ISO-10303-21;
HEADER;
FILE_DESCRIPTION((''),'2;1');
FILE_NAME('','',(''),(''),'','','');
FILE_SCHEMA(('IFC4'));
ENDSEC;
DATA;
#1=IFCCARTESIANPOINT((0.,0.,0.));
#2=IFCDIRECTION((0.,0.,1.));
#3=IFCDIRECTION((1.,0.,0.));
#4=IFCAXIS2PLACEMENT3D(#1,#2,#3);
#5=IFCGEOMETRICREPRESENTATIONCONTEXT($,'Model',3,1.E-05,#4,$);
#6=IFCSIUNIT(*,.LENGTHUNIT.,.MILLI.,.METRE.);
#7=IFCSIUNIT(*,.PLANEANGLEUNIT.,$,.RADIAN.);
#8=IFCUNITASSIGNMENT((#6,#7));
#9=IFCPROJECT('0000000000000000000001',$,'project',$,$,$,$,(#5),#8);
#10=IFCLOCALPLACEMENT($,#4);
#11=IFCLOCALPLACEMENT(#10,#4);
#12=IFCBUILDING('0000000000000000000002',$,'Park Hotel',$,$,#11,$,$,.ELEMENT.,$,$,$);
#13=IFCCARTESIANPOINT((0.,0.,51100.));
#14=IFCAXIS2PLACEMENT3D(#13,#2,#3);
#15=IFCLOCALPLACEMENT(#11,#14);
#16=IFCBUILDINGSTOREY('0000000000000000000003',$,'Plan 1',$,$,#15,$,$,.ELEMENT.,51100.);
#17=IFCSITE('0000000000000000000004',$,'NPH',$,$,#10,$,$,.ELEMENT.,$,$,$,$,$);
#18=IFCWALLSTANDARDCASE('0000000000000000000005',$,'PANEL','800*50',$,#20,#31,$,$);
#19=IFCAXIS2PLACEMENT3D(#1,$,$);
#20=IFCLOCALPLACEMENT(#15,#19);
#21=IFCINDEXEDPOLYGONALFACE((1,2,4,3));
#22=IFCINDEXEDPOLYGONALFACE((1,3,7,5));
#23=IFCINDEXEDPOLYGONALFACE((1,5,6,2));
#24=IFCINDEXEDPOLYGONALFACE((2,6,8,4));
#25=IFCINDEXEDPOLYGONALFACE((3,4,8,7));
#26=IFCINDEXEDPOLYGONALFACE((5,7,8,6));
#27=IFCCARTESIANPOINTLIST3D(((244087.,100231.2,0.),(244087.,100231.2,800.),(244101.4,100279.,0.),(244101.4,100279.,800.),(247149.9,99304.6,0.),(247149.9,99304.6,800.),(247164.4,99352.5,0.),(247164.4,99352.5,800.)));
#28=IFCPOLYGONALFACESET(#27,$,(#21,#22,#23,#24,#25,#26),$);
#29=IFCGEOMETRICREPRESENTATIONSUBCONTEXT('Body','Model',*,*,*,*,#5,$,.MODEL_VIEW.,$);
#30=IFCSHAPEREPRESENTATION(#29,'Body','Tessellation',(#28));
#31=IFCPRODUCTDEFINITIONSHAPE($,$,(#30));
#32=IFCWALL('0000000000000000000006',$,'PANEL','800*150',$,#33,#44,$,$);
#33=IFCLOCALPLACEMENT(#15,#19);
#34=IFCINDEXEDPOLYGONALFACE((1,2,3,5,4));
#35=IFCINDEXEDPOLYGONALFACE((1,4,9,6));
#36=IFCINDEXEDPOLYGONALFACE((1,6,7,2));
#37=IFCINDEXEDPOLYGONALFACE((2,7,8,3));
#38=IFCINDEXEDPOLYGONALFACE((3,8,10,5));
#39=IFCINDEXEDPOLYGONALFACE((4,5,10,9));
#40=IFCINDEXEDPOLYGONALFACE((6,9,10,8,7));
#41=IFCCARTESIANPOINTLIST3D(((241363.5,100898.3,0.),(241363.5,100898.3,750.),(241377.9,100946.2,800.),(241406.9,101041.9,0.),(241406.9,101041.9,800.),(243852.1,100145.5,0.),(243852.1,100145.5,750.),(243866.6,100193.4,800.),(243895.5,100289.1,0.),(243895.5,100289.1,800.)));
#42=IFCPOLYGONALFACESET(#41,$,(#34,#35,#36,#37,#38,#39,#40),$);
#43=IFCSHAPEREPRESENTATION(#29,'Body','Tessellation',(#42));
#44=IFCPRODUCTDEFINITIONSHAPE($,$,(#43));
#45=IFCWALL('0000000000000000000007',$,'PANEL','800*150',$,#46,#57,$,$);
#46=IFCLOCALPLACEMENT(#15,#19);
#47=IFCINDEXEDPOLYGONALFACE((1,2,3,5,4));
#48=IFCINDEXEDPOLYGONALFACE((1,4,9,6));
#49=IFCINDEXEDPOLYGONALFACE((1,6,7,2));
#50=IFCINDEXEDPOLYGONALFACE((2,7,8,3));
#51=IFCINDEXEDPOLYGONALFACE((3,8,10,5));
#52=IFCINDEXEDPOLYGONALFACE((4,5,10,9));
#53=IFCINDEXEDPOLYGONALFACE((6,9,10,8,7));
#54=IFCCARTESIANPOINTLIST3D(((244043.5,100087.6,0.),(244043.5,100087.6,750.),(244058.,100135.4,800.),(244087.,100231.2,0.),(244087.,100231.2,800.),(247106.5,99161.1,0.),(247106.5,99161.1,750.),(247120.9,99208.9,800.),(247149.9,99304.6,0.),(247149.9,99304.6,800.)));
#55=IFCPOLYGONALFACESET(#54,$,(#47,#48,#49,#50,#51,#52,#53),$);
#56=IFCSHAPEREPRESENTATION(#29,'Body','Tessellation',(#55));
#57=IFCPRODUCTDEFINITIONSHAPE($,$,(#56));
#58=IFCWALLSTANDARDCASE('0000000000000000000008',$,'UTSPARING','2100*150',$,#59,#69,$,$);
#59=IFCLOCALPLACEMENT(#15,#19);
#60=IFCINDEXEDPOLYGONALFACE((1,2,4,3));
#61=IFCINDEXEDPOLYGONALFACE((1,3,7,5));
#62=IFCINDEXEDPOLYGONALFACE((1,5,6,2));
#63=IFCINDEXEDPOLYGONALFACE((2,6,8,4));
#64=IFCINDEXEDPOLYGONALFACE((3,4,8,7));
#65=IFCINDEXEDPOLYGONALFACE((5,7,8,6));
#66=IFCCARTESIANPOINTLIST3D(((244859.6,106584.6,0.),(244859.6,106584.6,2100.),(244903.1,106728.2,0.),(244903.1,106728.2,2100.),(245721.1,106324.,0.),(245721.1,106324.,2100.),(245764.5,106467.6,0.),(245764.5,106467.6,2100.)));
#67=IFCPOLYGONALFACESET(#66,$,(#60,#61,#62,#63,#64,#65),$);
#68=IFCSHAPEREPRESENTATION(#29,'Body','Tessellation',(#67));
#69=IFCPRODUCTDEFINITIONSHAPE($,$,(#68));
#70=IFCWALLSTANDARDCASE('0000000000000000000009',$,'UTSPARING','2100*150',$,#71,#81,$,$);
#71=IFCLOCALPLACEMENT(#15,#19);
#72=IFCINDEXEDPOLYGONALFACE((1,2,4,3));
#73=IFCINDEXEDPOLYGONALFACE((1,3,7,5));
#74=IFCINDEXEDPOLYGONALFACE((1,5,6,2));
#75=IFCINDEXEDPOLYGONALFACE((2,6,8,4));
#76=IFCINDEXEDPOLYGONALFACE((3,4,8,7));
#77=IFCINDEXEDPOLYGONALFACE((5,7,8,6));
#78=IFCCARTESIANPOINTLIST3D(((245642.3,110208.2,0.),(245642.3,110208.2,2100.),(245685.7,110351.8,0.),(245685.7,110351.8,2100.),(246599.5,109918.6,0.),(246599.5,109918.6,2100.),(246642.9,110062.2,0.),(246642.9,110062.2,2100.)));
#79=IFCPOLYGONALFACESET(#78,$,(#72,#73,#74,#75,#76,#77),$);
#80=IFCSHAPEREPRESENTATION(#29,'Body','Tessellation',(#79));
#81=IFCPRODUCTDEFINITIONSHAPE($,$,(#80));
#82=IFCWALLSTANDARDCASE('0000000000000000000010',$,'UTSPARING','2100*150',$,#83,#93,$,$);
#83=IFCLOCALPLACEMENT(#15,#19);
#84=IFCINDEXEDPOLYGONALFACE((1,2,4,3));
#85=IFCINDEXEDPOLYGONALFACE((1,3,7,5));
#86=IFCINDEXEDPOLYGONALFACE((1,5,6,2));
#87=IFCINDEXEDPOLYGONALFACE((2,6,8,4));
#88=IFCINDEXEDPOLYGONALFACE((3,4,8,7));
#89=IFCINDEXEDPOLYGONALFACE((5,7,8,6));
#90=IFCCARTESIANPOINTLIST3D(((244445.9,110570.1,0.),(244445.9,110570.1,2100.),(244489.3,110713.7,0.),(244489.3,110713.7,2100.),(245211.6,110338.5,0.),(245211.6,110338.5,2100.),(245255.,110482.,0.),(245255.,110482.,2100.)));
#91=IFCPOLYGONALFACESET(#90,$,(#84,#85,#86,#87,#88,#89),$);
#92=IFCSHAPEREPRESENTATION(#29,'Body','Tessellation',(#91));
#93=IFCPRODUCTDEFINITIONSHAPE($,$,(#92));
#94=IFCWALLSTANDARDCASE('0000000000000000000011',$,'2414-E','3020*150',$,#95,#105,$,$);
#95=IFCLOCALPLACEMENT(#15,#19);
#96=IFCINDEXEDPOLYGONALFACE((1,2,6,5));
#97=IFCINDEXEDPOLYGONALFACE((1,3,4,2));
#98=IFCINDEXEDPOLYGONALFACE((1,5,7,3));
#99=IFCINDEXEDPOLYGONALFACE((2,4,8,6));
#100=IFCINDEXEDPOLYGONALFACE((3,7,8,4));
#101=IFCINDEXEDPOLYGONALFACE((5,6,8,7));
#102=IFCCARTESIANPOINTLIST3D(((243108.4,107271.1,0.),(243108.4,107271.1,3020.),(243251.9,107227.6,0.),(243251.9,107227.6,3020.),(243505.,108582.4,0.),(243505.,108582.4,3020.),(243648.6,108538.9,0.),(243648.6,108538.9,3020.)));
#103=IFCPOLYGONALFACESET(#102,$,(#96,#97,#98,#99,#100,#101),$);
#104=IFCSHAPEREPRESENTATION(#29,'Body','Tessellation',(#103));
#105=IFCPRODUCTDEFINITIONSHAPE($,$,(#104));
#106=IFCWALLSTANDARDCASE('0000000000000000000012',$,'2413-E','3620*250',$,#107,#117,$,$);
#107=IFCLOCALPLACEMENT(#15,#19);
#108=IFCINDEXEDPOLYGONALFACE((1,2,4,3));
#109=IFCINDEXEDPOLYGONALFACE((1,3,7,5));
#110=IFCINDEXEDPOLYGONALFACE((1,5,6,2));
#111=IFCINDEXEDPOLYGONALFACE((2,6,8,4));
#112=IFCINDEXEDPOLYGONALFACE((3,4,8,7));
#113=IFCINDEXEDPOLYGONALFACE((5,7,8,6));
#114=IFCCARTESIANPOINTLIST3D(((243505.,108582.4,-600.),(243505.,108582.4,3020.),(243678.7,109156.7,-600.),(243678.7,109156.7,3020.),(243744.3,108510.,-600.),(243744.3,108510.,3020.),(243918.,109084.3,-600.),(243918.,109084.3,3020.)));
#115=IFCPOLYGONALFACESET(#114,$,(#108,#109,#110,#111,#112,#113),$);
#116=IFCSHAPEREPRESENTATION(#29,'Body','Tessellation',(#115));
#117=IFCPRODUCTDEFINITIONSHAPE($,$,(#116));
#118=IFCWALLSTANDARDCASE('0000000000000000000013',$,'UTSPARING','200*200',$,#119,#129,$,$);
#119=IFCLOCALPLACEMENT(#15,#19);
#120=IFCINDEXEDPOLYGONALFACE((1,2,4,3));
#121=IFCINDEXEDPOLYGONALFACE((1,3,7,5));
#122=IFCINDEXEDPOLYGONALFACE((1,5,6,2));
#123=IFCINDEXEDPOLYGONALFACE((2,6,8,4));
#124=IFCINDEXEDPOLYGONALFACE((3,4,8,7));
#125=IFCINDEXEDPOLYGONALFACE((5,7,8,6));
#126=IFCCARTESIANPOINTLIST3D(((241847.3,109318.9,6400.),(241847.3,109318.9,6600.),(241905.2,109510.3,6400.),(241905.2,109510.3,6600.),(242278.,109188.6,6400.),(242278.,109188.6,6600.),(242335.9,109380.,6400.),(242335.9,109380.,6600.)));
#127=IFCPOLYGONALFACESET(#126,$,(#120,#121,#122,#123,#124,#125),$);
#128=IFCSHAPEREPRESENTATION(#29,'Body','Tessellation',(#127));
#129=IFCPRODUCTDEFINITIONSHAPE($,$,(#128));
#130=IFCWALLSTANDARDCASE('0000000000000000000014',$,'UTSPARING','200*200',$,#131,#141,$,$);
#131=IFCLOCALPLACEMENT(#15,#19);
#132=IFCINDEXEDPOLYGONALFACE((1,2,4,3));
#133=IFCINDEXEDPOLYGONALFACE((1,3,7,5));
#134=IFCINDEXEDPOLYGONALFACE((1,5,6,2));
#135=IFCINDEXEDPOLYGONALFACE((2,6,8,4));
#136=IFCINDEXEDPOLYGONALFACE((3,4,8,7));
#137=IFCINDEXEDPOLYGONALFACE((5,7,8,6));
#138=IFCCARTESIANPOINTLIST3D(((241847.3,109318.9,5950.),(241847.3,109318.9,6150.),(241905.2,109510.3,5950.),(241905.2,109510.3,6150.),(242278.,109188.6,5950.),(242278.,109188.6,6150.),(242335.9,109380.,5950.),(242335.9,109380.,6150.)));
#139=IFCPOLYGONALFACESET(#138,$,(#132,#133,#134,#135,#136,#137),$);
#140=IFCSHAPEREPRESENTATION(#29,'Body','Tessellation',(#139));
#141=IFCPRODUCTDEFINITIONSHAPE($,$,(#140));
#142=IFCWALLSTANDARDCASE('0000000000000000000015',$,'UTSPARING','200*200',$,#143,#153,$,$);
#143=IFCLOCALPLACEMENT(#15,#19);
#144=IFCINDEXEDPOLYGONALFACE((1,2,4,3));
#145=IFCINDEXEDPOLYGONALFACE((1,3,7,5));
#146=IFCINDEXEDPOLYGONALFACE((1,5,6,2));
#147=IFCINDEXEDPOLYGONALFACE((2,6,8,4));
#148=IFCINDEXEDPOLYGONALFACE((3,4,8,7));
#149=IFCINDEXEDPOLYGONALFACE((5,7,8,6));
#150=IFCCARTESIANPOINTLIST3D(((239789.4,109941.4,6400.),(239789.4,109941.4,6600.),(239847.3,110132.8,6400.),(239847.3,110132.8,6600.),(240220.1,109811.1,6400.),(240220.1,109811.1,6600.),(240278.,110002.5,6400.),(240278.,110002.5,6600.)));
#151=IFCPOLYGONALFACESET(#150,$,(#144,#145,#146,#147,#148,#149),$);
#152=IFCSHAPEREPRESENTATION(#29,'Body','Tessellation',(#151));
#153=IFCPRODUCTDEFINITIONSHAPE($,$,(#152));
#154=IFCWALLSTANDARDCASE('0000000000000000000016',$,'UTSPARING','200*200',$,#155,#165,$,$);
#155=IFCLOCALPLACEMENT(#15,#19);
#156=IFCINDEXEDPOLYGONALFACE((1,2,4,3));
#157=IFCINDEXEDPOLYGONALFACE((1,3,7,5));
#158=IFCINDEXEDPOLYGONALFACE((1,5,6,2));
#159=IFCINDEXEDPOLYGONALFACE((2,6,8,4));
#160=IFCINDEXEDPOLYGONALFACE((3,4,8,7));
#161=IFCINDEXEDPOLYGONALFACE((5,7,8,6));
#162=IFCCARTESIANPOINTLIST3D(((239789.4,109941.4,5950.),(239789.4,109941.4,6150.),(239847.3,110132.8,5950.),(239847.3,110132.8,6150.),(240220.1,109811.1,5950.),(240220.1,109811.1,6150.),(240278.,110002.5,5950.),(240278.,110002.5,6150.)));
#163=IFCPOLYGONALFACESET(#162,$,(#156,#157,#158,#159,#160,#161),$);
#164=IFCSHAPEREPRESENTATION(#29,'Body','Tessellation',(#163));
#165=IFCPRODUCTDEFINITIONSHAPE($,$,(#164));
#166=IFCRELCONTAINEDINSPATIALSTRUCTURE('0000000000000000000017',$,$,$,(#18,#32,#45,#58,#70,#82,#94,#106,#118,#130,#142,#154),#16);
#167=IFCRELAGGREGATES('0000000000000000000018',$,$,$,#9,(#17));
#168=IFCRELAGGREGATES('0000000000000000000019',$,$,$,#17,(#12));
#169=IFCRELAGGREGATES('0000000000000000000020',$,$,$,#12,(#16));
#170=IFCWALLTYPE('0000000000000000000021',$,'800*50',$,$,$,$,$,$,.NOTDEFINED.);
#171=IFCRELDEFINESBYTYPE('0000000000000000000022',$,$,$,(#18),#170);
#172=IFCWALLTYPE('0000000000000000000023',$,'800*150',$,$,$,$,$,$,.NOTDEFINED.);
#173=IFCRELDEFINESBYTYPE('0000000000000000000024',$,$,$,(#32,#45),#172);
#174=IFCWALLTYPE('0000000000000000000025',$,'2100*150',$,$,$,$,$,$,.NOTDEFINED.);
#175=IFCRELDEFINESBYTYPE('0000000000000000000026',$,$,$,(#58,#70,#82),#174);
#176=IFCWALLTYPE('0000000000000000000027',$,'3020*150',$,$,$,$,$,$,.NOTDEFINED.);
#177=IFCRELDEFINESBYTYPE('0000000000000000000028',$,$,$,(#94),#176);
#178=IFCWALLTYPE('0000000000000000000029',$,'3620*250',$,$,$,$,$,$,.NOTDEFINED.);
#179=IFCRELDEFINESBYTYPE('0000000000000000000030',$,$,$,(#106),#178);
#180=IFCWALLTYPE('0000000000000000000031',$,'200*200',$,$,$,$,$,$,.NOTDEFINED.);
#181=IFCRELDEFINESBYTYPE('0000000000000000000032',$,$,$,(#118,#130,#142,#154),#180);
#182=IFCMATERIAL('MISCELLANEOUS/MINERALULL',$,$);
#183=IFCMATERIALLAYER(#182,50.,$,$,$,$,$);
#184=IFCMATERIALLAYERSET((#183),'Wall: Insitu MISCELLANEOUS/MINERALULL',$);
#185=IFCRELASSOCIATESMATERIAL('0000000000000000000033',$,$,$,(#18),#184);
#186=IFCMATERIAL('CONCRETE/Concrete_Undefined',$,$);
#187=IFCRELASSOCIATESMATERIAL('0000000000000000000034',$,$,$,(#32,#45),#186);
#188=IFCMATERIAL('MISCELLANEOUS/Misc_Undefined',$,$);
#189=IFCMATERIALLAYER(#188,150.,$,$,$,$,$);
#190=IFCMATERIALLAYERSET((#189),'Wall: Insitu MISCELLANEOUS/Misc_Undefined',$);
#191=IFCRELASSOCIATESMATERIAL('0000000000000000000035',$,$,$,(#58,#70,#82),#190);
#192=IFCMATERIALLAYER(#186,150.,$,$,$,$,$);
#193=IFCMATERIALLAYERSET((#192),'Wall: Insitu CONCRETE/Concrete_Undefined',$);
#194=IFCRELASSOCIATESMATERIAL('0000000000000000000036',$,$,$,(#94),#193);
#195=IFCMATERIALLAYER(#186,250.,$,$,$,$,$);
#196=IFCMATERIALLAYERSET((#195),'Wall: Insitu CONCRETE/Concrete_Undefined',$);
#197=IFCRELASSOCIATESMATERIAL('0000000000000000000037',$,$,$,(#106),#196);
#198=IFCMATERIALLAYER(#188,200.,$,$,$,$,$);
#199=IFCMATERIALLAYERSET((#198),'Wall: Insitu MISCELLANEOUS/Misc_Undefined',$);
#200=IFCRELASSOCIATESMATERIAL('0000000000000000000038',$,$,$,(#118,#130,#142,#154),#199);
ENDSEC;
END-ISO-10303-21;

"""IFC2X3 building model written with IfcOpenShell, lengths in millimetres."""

from ifc_helpers import new_model, si_unit, frame, frame_2d, origin_with_axes, place, context, subcontext, project, spatial, rectangle, extrude, clip, halfspace, material, layer, layer_set, layer_usage, type_object, element, save


model = new_model("IFC2X3")

# Units and contexts
model_context = context("Model", 3, precision=1e-05, world=origin_with_axes())
body_context = subcontext(model_context, "Body", "Model", "MODEL_VIEW")
ifc_project = project(units=[si_unit("LENGTHUNIT", "METRE", prefix="MILLI"), si_unit("PLANEANGLEUNIT", "RADIAN")], contexts=[model_context])

# Site, building, storey
site_placement = place(None, origin_with_axes())
site = spatial("IfcSite", under=ifc_project, at=site_placement, Name="NPH", CompositionType="ELEMENT")
building_placement = place(site_placement, origin_with_axes())
building = spatial("IfcBuilding", under=site, at=building_placement, Name="Park Hotel", CompositionType="ELEMENT")
storey_placement = place(building_placement, frame((0.0, 0.0, 51100.0), z_axis=(0.0, 0.0, 1.0), x_axis=(1.0, 0.0, 0.0)))
storey = spatial("IfcBuildingStorey", under=building, at=storey_placement, Name="Plan 1", CompositionType="ELEMENT", Elevation=51100.0)

# Shared definitions
ifc_material_1 = material(Name="CONCRETE/Concrete_Undefined")

# Walls
ifc_material_2 = material(Name="MISCELLANEOUS/MINERALULL")
ifc_layer_1 = layer(ifc_material_2, 50.0)
ifc_layer_set_1 = layer_set([ifc_layer_1], Name="Wall: Insitu MISCELLANEOUS/MINERALULL")
wall_type_1 = type_object("IfcWallType", Name="800*50", PredefinedType="NOTDEFINED")
ifc_layer_usage_1 = layer_usage(ifc_layer_set_1, "AXIS2", "POSITIVE", -25.0)
wall_1_placement = place(storey_placement, frame((244094.2, 100255.1, 0.0), z_axis=(0.0, 0.0, 1.0), x_axis=(0.957166, -0.289539, 0.0)))
element("IfcWallStandardCase", 1, at=wall_1_placement, inside=storey, type_object=wall_type_1, material=ifc_layer_usage_1, Name="PANEL", Description="800*50", context=body_context, shape_type="SweptSolid", body=[
    extrude(rectangle(XDim=3200.0, YDim=50.0, at=frame_2d((0.0, 1600.0), x_axis=(0.0, -1.0))), frame((0.0, 0.0, 0.0), z_axis=(0.0, 0.0, 1.0), x_axis=(0.0, -1.0, 0.0)), (0.0, 0.0, 1.0), 800.0),
])
wall_type_2 = type_object("IfcWallType", Name="800*150", PredefinedType="NOTDEFINED")
wall_2_placement = place(storey_placement, frame((241385.2, 100970.1, 0.0), z_axis=(0.0, 0.0, 1.0), x_axis=(0.957166, -0.289539, 0.0)))
element("IfcWall", 2, at=wall_2_placement, inside=storey, type_object=wall_type_2, material=ifc_material_1, Name="PANEL", Description="800*150", context=body_context, shape_type="Clipping", body=[
    clip(extrude(rectangle(XDim=2600.0, YDim=150.0, at=frame_2d((0.0, 1300.0), x_axis=(0.0, -1.0))), frame((0.0, 0.0, 0.0), z_axis=(0.0, 0.0, 1.0), x_axis=(0.0, -1.0, 0.0)), (0.0, 0.0, 1.0), 800.0), halfspace(frame((2600.0, 75.0, 900.0), z_axis=(0.000001, -0.707072, 0.707141), x_axis=(0.0, -0.707141, -0.707072)), False)),
])
wall_3_placement = place(storey_placement, frame((244065.2, 100159.4, 0.0), z_axis=(0.0, 0.0, 1.0), x_axis=(0.957166, -0.289539, 0.0)))
element("IfcWall", 3, at=wall_3_placement, inside=storey, type_object=wall_type_2, material=ifc_material_1, Name="PANEL", Description="800*150", context=body_context, shape_type="Clipping", body=[
    clip(extrude(rectangle(XDim=3200.0, YDim=150.0, at=frame_2d((0.0, 1600.0), x_axis=(0.0, -1.0))), frame((0.0, 0.0, 0.0), z_axis=(0.0, 0.0, 1.0), x_axis=(0.0, -1.0, 0.0)), (0.0, 0.0, 1.0), 800.0), halfspace(frame((3200.0, 75.0, 900.0), z_axis=(0.000001, -0.707072, 0.707141), x_axis=(0.0, -0.707141, -0.707072)), False)),
])
ifc_material_3 = material(Name="MISCELLANEOUS/Misc_Undefined")
ifc_layer_2 = layer(ifc_material_3, 150.0)
ifc_layer_set_2 = layer_set([ifc_layer_2], Name="Wall: Insitu MISCELLANEOUS/Misc_Undefined")
ifc_layer_usage_2 = layer_usage(ifc_layer_set_2, "AXIS2", "POSITIVE", -75.0)
wall_type_3 = type_object("IfcWallType", Name="2100*150", PredefinedType="NOTDEFINED")
wall_4_placement = place(storey_placement, frame((244881.3, 106656.4, 0.0), z_axis=(0.0, 0.0, 1.0), x_axis=(0.957166, -0.289541, 0.0)))
element("IfcWallStandardCase", 4, at=wall_4_placement, inside=storey, type_object=wall_type_3, material=ifc_layer_usage_2, Name="UTSPARING", Description="2100*150", context=body_context, shape_type="SweptSolid", body=[
    extrude(rectangle(XDim=900.0, YDim=150.0, at=frame_2d((0.0, 450.0), x_axis=(0.0, -1.0))), frame((0.0, 0.0, 0.0), z_axis=(0.0, 0.0, 1.0), x_axis=(0.0, -1.0, 0.0)), (0.0, 0.0, 1.0), 2100.0),
])
ifc_layer_usage_3 = layer_usage(ifc_layer_set_2, "AXIS2", "POSITIVE", -75.0)
wall_5_placement = place(storey_placement, frame((245664.0, 110280.0, 0.0), z_axis=(0.0, 0.0, 1.0), x_axis=(0.957166, -0.289541, 0.0)))
element("IfcWallStandardCase", 5, at=wall_5_placement, inside=storey, type_object=wall_type_3, material=ifc_layer_usage_3, Name="UTSPARING", Description="2100*150", context=body_context, shape_type="SweptSolid", body=[
    extrude(rectangle(XDim=1000.0, YDim=150.0, at=frame_2d((0.0, 500.0), x_axis=(0.0, -1.0))), frame((0.0, 0.0, 0.0), z_axis=(0.0, 0.0, 1.0), x_axis=(0.0, -1.0, 0.0)), (0.0, 0.0, 1.0), 2100.0),
])
ifc_layer_usage_4 = layer_usage(ifc_layer_set_2, "AXIS2", "POSITIVE", -75.0)
wall_6_placement = place(storey_placement, frame((244467.6, 110641.9, 0.0), z_axis=(0.0, 0.0, 1.0), x_axis=(0.957166, -0.289541, 0.0)))
element("IfcWallStandardCase", 6, at=wall_6_placement, inside=storey, type_object=wall_type_3, material=ifc_layer_usage_4, Name="UTSPARING", Description="2100*150", context=body_context, shape_type="SweptSolid", body=[
    extrude(rectangle(XDim=800.0, YDim=150.0, at=frame_2d((0.0, 400.0), x_axis=(0.0, -1.0))), frame((0.0, 0.0, 0.0), z_axis=(0.0, 0.0, 1.0), x_axis=(0.0, -1.0, 0.0)), (0.0, 0.0, 1.0), 2100.0),
])
ifc_layer_3 = layer(ifc_material_1, 150.0)
ifc_layer_set_3 = layer_set([ifc_layer_3], Name="Wall: Insitu CONCRETE/Concrete_Undefined")
ifc_layer_usage_5 = layer_usage(ifc_layer_set_3, "AXIS2", "POSITIVE", -75.0)
wall_type_4 = type_object("IfcWallType", Name="3020*150", PredefinedType="NOTDEFINED")
wall_7_placement = place(storey_placement, frame((243180.1, 107249.3, 0.0), z_axis=(0.0, 0.0, 1.0), x_axis=(0.289542, 0.957165, 0.0)))
element("IfcWallStandardCase", 7, at=wall_7_placement, inside=storey, type_object=wall_type_4, material=ifc_layer_usage_5, Name="2414-E", Description="3020*150", context=body_context, shape_type="SweptSolid", body=[
    extrude(rectangle(XDim=1370.0, YDim=150.0, at=frame_2d((0.0, 685.0), x_axis=(0.0, -1.0))), frame((0.0, 0.0, 0.0), z_axis=(0.0, 0.0, 1.0), x_axis=(0.0, -1.0, 0.0)), (0.0, 0.0, 1.0), 3020.0),
])
ifc_layer_4 = layer(ifc_material_1, 250.0)
ifc_layer_set_4 = layer_set([ifc_layer_4], Name="Wall: Insitu CONCRETE/Concrete_Undefined")
ifc_layer_usage_6 = layer_usage(ifc_layer_set_4, "AXIS2", "POSITIVE", -125.0)
wall_type_5 = type_object("IfcWallType", Name="3620*250", PredefinedType="NOTDEFINED")
wall_8_placement = place(storey_placement, frame((243624.7, 108546.2, -600.0), z_axis=(0.0, 0.0, 1.0), x_axis=(0.28953, 0.957169, 0.0)))
element("IfcWallStandardCase", 8, at=wall_8_placement, inside=storey, type_object=wall_type_5, material=ifc_layer_usage_6, Name="2413-E", Description="3620*250", context=body_context, shape_type="SweptSolid", body=[
    extrude(rectangle(XDim=600.0, YDim=250.0, at=frame_2d((0.0, 300.0), x_axis=(0.0, -1.0))), frame((0.0, 0.0, 0.0), z_axis=(0.0, 0.0, 1.0), x_axis=(0.0, -1.0, 0.0)), (0.0, 0.0, 1.0), 3620.0),
])
ifc_layer_5 = layer(ifc_material_3, 200.0)
ifc_layer_set_5 = layer_set([ifc_layer_5], Name="Wall: Insitu MISCELLANEOUS/Misc_Undefined")
ifc_layer_usage_7 = layer_usage(ifc_layer_set_5, "AXIS2", "POSITIVE", -100.0)
wall_type_6 = type_object("IfcWallType", Name="200*200", PredefinedType="NOTDEFINED")
wall_9_placement = place(storey_placement, frame((241876.2, 109414.6, 6400.0), z_axis=(0.0, 0.0, 1.0), x_axis=(0.957164, -0.289545, 0.0)))
element("IfcWallStandardCase", 9, at=wall_9_placement, inside=storey, type_object=wall_type_6, material=ifc_layer_usage_7, Name="UTSPARING", Description="200*200", context=body_context, shape_type="SweptSolid", body=[
    extrude(rectangle(XDim=450.0, YDim=200.0, at=frame_2d((0.0, 225.0), x_axis=(0.0, -1.0))), frame((0.0, 0.0, 0.0), z_axis=(0.0, 0.0, 1.0), x_axis=(0.0, -1.0, 0.0)), (0.0, 0.0, 1.0), 200.0),
])
ifc_layer_usage_8 = layer_usage(ifc_layer_set_5, "AXIS2", "POSITIVE", -100.0)
wall_10_placement = place(storey_placement, frame((241876.2, 109414.6, 5950.0), z_axis=(0.0, 0.0, 1.0), x_axis=(0.957164, -0.289545, 0.0)))
element("IfcWallStandardCase", 10, at=wall_10_placement, inside=storey, type_object=wall_type_6, material=ifc_layer_usage_8, Name="UTSPARING", Description="200*200", context=body_context, shape_type="SweptSolid", body=[
    extrude(rectangle(XDim=450.0, YDim=200.0, at=frame_2d((0.0, 225.0), x_axis=(0.0, -1.0))), frame((0.0, 0.0, 0.0), z_axis=(0.0, 0.0, 1.0), x_axis=(0.0, -1.0, 0.0)), (0.0, 0.0, 1.0), 200.0),
])
ifc_layer_usage_9 = layer_usage(ifc_layer_set_5, "AXIS2", "POSITIVE", -100.0)
wall_11_placement = place(storey_placement, frame((239818.3, 110037.1, 6400.0), z_axis=(0.0, 0.0, 1.0), x_axis=(0.957164, -0.289545, 0.0)))
element("IfcWallStandardCase", 11, at=wall_11_placement, inside=storey, type_object=wall_type_6, material=ifc_layer_usage_9, Name="UTSPARING", Description="200*200", context=body_context, shape_type="SweptSolid", body=[
    extrude(rectangle(XDim=450.0, YDim=200.0, at=frame_2d((0.0, 225.0), x_axis=(0.0, -1.0))), frame((0.0, 0.0, 0.0), z_axis=(0.0, 0.0, 1.0), x_axis=(0.0, -1.0, 0.0)), (0.0, 0.0, 1.0), 200.0),
])
ifc_layer_usage_10 = layer_usage(ifc_layer_set_5, "AXIS2", "POSITIVE", -100.0)
wall_12_placement = place(storey_placement, frame((239818.3, 110037.1, 5950.0), z_axis=(0.0, 0.0, 1.0), x_axis=(0.957164, -0.289545, 0.0)))
element("IfcWallStandardCase", 12, at=wall_12_placement, inside=storey, type_object=wall_type_6, material=ifc_layer_usage_10, Name="UTSPARING", Description="200*200", context=body_context, shape_type="SweptSolid", body=[
    extrude(rectangle(XDim=450.0, YDim=200.0, at=frame_2d((0.0, 225.0), x_axis=(0.0, -1.0))), frame((0.0, 0.0, 0.0), z_axis=(0.0, 0.0, 1.0), x_axis=(0.0, -1.0, 0.0)), (0.0, 0.0, 1.0), 200.0),
])

save(model, "model.ifc")
